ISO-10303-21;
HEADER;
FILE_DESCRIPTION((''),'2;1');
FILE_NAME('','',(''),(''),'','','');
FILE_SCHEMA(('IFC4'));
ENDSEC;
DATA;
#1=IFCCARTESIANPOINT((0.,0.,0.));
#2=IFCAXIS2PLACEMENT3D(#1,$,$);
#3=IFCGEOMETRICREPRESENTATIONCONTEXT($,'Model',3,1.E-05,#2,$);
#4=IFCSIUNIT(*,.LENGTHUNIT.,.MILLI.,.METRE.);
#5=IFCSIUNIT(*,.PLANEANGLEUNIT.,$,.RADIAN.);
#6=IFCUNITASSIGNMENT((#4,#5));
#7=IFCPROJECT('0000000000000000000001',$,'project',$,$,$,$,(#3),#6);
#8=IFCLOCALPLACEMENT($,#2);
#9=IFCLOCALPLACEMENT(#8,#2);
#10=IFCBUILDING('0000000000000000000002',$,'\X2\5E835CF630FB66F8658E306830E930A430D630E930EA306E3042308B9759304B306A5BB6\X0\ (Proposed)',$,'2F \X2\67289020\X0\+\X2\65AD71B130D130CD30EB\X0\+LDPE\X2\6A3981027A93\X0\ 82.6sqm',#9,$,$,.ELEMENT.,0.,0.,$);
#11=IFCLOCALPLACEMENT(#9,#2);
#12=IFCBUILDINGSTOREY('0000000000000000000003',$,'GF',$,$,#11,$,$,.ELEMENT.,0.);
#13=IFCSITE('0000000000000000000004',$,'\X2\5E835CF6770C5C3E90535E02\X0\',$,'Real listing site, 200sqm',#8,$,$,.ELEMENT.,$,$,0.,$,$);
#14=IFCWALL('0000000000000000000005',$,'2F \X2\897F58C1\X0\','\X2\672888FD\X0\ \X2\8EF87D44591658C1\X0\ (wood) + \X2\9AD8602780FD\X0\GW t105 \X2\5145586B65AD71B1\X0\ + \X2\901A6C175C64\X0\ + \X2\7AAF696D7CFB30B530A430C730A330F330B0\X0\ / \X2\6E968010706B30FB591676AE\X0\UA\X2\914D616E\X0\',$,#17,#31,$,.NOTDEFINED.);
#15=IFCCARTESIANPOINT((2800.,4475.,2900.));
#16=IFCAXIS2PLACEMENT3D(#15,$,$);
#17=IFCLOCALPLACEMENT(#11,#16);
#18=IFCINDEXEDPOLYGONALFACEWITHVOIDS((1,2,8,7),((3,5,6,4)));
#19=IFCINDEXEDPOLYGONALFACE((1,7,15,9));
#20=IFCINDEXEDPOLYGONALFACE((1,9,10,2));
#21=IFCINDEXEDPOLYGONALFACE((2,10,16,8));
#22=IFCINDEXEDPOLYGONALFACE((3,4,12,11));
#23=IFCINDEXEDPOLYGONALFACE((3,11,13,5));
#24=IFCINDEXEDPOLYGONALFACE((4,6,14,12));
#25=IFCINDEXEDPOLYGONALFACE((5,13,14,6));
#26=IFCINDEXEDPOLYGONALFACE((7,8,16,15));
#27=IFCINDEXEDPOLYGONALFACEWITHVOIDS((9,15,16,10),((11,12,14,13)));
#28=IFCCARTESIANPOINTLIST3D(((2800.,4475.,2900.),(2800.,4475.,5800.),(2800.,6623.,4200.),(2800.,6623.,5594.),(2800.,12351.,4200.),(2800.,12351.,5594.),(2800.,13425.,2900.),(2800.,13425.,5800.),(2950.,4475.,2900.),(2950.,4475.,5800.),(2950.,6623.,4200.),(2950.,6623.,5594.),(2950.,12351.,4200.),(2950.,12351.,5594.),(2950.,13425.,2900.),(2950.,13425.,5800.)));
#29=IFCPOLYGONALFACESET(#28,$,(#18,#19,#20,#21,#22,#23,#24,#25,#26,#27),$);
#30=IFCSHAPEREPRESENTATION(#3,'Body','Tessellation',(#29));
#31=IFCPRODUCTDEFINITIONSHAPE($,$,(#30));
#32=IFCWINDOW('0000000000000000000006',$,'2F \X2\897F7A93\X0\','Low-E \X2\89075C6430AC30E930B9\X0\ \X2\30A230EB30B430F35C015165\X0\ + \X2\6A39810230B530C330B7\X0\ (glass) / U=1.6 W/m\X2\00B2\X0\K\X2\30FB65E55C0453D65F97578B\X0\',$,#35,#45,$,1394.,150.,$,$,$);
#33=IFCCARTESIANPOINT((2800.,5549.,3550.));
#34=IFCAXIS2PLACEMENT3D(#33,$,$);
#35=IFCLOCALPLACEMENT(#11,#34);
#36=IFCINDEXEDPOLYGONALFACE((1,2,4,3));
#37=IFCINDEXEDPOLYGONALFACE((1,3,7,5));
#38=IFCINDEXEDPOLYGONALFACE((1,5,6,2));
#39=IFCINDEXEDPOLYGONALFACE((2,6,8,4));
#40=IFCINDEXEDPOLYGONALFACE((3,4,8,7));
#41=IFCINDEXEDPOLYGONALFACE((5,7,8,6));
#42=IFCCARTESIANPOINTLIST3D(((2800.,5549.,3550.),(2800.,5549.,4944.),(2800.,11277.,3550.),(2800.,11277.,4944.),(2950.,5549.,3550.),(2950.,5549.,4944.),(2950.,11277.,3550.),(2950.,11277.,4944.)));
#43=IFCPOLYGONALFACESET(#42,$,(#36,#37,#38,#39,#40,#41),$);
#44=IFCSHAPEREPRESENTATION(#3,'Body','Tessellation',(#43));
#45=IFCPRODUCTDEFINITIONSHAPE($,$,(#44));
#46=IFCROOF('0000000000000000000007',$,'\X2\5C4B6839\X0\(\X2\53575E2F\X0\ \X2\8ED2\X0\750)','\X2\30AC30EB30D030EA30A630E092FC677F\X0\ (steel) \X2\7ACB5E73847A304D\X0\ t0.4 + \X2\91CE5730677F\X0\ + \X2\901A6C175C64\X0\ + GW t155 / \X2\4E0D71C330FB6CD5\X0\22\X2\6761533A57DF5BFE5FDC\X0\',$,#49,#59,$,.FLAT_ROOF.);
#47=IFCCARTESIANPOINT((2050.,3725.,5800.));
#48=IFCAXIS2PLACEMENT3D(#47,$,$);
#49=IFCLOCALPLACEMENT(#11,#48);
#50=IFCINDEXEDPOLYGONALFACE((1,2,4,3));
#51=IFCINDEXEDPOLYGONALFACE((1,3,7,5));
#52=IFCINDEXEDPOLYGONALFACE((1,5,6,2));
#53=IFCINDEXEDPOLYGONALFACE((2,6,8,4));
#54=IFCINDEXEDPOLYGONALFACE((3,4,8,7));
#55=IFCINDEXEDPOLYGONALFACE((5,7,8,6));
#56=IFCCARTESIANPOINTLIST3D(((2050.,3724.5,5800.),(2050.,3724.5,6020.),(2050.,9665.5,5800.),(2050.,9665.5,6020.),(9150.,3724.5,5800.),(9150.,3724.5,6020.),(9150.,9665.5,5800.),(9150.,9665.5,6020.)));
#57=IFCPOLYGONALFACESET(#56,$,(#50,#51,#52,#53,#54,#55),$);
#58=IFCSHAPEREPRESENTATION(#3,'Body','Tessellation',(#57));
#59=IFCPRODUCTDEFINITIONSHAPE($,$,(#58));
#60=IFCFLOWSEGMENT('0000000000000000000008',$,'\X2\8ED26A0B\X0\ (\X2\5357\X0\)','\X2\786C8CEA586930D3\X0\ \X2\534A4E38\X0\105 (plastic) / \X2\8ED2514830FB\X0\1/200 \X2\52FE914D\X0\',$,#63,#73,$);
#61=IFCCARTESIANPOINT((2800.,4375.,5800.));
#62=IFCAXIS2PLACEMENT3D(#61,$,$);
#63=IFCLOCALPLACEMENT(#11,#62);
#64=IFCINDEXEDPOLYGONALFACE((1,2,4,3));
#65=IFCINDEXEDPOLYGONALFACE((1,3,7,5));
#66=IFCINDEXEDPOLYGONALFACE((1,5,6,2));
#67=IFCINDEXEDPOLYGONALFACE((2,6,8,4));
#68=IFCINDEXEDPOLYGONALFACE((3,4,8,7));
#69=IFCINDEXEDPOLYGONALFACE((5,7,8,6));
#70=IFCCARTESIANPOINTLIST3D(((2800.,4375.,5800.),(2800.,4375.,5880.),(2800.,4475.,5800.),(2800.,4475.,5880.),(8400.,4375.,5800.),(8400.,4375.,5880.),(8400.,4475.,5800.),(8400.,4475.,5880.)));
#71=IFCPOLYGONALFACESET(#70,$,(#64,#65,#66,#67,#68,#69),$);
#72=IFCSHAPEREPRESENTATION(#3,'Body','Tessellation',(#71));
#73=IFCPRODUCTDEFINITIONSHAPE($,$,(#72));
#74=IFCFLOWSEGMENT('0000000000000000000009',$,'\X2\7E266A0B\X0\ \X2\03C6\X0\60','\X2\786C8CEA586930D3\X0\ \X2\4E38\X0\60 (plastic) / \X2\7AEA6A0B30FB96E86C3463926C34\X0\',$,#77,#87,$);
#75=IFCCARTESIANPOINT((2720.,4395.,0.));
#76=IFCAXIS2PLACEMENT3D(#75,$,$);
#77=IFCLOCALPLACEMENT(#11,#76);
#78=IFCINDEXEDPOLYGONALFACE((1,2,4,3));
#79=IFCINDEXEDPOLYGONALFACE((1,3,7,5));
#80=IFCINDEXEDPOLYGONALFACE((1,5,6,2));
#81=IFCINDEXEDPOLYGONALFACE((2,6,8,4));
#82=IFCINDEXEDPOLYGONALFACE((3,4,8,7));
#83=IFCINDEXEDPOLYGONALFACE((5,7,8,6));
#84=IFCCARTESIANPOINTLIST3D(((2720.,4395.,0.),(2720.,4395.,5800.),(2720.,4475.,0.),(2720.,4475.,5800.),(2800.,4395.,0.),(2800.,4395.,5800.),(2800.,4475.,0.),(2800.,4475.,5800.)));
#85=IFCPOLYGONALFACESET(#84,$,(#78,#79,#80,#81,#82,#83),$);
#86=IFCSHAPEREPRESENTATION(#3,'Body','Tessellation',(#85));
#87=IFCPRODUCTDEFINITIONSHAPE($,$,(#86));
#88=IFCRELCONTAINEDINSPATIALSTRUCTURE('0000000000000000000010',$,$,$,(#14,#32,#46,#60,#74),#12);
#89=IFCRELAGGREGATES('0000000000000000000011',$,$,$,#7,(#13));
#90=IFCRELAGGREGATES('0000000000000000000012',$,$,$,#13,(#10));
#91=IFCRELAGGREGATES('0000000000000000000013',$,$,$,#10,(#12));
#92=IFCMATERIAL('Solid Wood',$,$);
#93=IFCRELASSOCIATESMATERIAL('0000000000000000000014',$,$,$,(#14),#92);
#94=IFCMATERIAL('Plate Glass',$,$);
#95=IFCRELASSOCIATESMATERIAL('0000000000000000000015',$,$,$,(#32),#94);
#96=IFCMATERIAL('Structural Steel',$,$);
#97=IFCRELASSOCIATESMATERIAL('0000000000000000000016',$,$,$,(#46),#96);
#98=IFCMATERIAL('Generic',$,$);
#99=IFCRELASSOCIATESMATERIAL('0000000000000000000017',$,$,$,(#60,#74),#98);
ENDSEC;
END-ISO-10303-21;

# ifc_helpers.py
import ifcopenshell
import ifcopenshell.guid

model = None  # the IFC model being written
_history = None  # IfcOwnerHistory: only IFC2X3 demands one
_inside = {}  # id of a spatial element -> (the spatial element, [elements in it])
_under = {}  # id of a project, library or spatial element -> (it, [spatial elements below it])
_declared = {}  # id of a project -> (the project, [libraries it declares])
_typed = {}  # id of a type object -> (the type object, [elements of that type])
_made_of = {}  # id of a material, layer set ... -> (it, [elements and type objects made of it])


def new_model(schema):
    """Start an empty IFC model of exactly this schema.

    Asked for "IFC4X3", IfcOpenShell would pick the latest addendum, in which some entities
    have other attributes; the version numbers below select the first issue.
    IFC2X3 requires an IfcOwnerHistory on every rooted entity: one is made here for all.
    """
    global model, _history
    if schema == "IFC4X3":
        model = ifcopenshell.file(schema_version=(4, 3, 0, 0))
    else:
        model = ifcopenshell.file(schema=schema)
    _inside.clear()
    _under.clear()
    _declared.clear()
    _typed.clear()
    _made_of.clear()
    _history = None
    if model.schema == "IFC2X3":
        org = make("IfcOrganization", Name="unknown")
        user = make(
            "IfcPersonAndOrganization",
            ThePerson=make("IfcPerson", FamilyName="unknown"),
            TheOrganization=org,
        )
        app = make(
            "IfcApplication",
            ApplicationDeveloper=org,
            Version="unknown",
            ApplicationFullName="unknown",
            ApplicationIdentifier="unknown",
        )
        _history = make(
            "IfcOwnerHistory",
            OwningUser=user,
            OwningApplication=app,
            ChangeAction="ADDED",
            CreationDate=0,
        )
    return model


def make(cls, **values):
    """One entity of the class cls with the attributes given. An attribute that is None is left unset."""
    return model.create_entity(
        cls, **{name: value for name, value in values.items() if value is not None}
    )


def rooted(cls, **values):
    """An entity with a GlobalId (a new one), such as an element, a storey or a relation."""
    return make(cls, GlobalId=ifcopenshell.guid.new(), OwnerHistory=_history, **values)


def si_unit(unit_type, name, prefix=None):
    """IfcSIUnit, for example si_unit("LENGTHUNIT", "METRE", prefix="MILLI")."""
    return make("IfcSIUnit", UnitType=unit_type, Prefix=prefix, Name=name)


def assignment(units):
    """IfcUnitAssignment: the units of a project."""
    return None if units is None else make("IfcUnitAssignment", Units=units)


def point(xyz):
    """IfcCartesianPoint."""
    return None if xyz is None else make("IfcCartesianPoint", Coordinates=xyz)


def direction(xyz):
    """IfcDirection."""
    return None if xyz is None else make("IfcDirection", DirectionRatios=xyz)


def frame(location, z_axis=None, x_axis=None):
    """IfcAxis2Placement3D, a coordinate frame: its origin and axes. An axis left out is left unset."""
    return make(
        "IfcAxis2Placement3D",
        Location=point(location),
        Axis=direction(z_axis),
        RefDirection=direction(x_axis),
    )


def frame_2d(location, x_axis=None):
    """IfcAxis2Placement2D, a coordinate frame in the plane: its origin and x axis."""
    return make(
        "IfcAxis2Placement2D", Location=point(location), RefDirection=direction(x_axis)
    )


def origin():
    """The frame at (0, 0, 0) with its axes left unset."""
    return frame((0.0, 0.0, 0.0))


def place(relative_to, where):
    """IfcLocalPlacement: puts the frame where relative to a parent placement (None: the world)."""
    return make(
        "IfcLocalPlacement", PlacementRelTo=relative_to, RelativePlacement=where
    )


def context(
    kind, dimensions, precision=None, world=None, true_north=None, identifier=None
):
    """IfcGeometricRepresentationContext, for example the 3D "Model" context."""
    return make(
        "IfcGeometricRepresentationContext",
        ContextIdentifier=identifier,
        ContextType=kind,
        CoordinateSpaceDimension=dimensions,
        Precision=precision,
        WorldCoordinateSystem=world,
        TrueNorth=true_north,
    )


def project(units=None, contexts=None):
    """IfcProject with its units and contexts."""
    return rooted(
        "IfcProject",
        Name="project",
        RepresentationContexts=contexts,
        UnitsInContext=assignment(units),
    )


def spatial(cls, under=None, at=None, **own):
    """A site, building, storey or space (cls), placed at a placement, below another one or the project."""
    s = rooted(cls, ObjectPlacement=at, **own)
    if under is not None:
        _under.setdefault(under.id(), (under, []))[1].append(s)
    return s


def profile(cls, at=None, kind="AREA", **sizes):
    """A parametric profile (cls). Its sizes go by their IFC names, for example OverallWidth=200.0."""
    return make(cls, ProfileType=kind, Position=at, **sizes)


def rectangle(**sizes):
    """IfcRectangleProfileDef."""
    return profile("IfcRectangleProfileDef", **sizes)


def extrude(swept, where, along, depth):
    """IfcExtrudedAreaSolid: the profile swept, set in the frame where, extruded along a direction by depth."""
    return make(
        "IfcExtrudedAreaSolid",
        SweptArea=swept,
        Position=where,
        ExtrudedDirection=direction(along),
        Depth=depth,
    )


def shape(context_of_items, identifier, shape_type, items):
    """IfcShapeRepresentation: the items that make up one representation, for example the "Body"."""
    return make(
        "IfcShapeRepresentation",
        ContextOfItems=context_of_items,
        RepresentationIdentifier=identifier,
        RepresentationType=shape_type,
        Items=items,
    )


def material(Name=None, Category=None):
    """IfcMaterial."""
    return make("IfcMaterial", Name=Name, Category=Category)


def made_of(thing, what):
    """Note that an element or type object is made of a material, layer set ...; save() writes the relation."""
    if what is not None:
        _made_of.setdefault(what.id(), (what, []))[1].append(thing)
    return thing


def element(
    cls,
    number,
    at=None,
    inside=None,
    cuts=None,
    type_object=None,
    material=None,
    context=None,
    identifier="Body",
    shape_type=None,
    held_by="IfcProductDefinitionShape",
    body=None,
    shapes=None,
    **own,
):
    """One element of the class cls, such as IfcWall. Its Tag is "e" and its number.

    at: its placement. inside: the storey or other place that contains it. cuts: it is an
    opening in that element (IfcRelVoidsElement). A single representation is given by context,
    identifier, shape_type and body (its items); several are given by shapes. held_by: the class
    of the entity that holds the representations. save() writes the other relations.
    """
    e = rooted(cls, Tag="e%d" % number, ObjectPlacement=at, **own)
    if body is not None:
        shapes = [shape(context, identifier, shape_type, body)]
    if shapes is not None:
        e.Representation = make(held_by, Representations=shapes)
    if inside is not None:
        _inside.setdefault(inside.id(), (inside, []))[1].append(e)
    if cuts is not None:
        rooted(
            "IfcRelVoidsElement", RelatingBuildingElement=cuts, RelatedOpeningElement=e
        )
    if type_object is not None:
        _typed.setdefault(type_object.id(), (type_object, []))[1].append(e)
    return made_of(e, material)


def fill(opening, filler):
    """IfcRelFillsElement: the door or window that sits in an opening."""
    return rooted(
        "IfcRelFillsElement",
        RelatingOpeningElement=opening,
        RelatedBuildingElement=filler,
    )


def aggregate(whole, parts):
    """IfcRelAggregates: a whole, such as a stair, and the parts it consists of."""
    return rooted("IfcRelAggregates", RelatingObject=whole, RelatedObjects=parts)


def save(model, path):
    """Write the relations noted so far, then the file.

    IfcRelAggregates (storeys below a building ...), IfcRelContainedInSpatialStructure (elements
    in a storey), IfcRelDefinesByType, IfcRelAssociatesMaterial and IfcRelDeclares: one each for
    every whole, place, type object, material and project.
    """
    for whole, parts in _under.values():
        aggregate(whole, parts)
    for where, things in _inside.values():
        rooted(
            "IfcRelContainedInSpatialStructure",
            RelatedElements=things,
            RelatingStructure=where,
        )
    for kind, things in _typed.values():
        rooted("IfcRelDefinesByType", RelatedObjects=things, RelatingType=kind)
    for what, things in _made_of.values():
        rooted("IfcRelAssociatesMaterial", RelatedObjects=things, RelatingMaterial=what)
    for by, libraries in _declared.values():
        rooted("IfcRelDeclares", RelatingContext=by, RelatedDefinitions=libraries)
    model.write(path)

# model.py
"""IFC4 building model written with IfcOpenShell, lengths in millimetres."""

from ifc_helpers import new_model, si_unit, frame, frame_2d, origin, place, context, project, spatial, rectangle, extrude, material, element, fill, save


model = new_model("IFC4")

# Units and contexts
model_context = context("Model", 3, precision=1e-05, world=origin())
ifc_project = project(units=[si_unit("LENGTHUNIT", "METRE", prefix="MILLI"), si_unit("PLANEANGLEUNIT", "RADIAN")], contexts=[model_context])

# Site, building, storey
site_placement = place(None, origin())
site = spatial("IfcSite", under=ifc_project, at=site_placement, Name="広島県尾道市", ObjectType="Real listing site, 200sqm", CompositionType="ELEMENT", RefElevation=0.0)
building_placement = place(site_placement, origin())
building = spatial("IfcBuilding", under=site, at=building_placement, Name="広島・書斎とライブラリのある静かな家 (Proposed)", ObjectType="2F 木造+断熱パネル+LDPE樹脂窓 82.6sqm", CompositionType="ELEMENT", ElevationOfRefHeight=0.0, ElevationOfTerrain=0.0)
storey_placement = place(building_placement, origin())
storey = spatial("IfcBuildingStorey", under=building, at=storey_placement, Name="GF", CompositionType="ELEMENT", Elevation=0.0)

# Shared definitions
ifc_material_1 = material(Name="Solid Wood")

# Shared definitions
ifc_material_2 = material(Name="Plate Glass")

# Wall, opening, window
wall_1_placement = place(storey_placement, frame((2800.0, 4475.0, 2900.0)))
wall_1 = element("IfcWall", 1, at=wall_1_placement, inside=storey, material=ifc_material_1, Name="2F 西壁", Description="木製 軸組外壁 (wood) + 高性能GW t105 充填断熱 + 通気層 + 窯業系サイディング / 準耐火・外皮UA配慮", PredefinedType="NOTDEFINED", context=model_context, shape_type="SweptSolid", body=[
    extrude(rectangle(XDim=150.0, YDim=8950.0, at=frame_2d((75.0, 4475.0))), frame((2800.0, 4475.0, 2900.0)), (0.0, 0.0, 1.0), 2900.0),
])
opening_1_placement = place(storey_placement, frame((2800.0, 5549.0, 3550.0)))
opening_1 = element("IfcOpeningElement", 2, at=opening_1_placement, cuts=wall_1, PredefinedType="NOTDEFINED", context=model_context, shape_type="SweptSolid", body=[
    extrude(rectangle(XDim=150.0, YDim=5728.0, at=frame_2d((75.0, 2864.0))), frame((2800.0, 5549.0, 3550.0)), (0.0, 0.0, 1.0), 1394.0),
])
window_1_placement = place(storey_placement, frame((2800.0, 5549.0, 3550.0)))
window_1 = element("IfcWindow", 3, at=window_1_placement, inside=storey, material=ifc_material_2, Name="2F 西窓", Description="Low-E 複層ガラス アルゴン封入 + 樹脂サッシ (glass) / U=1.6 W/m²K・日射取得型", OverallHeight=1394.0, OverallWidth=150.0, context=model_context, shape_type="SweptSolid", body=[
    extrude(rectangle(XDim=150.0, YDim=5728.0, at=frame_2d((75.0, 2864.0))), frame((2800.0, 5549.0, 3550.0)), (0.0, 0.0, 1.0), 1394.0),
])
fill(opening_1, window_1)

# Roof
ifc_material_3 = material(Name="Structural Steel")
for number, where, name in (
    (4, (2050.0, 3725.0, 5800.0), "屋根(南帯 軒750)"),
):
    element("IfcRoof", number, at=place(storey_placement, frame(where)), inside=storey, material=ifc_material_3, Name=name, Description="ガルバリウム鋼板 (steel) 立平葺き t0.4 + 野地板 + 通気層 + GW t155 / 不燃・法22条区域対応", PredefinedType="FLAT_ROOF", context=model_context, shape_type="SweptSolid", body=[
        extrude(rectangle(XDim=7100.0, YDim=5941.0, at=frame_2d((3550.0, 2970.0))), frame((2050.0, 3725.0, 5800.0)), (0.0, 0.0, 1.0), 220.0),
    ])

# Flow segments
ifc_material_4 = material(Name="Generic")
flow_segment_1_placement = place(storey_placement, frame((2800.0, 4375.0, 5800.0)))
element("IfcFlowSegment", 5, at=flow_segment_1_placement, inside=storey, material=ifc_material_4, Name="軒樋 (南)", Description="硬質塩ビ 半丸105 (plastic) / 軒先・1/200 勾配", context=model_context, shape_type="SweptSolid", body=[
    extrude(rectangle(XDim=5600.0, YDim=100.0, at=frame_2d((2800.0, 50.0))), frame((2800.0, 4375.0, 5800.0)), (0.0, 0.0, 1.0), 80.0),
])
flow_segment_2_placement = place(storey_placement, frame((2720.0, 4395.0, 0.0)))
element("IfcFlowSegment", 6, at=flow_segment_2_placement, inside=storey, material=ifc_material_4, Name="縦樋 φ60", Description="硬質塩ビ 丸60 (plastic) / 竪樋・雨水排水", context=model_context, shape_type="SweptSolid", body=[
    extrude(rectangle(XDim=80.0, YDim=80.0, at=frame_2d((40.0, 40.0))), frame((2720.0, 4395.0, 0.0)), (0.0, 0.0, 1.0), 5800.0),
])

save(model, "model.ifc")
